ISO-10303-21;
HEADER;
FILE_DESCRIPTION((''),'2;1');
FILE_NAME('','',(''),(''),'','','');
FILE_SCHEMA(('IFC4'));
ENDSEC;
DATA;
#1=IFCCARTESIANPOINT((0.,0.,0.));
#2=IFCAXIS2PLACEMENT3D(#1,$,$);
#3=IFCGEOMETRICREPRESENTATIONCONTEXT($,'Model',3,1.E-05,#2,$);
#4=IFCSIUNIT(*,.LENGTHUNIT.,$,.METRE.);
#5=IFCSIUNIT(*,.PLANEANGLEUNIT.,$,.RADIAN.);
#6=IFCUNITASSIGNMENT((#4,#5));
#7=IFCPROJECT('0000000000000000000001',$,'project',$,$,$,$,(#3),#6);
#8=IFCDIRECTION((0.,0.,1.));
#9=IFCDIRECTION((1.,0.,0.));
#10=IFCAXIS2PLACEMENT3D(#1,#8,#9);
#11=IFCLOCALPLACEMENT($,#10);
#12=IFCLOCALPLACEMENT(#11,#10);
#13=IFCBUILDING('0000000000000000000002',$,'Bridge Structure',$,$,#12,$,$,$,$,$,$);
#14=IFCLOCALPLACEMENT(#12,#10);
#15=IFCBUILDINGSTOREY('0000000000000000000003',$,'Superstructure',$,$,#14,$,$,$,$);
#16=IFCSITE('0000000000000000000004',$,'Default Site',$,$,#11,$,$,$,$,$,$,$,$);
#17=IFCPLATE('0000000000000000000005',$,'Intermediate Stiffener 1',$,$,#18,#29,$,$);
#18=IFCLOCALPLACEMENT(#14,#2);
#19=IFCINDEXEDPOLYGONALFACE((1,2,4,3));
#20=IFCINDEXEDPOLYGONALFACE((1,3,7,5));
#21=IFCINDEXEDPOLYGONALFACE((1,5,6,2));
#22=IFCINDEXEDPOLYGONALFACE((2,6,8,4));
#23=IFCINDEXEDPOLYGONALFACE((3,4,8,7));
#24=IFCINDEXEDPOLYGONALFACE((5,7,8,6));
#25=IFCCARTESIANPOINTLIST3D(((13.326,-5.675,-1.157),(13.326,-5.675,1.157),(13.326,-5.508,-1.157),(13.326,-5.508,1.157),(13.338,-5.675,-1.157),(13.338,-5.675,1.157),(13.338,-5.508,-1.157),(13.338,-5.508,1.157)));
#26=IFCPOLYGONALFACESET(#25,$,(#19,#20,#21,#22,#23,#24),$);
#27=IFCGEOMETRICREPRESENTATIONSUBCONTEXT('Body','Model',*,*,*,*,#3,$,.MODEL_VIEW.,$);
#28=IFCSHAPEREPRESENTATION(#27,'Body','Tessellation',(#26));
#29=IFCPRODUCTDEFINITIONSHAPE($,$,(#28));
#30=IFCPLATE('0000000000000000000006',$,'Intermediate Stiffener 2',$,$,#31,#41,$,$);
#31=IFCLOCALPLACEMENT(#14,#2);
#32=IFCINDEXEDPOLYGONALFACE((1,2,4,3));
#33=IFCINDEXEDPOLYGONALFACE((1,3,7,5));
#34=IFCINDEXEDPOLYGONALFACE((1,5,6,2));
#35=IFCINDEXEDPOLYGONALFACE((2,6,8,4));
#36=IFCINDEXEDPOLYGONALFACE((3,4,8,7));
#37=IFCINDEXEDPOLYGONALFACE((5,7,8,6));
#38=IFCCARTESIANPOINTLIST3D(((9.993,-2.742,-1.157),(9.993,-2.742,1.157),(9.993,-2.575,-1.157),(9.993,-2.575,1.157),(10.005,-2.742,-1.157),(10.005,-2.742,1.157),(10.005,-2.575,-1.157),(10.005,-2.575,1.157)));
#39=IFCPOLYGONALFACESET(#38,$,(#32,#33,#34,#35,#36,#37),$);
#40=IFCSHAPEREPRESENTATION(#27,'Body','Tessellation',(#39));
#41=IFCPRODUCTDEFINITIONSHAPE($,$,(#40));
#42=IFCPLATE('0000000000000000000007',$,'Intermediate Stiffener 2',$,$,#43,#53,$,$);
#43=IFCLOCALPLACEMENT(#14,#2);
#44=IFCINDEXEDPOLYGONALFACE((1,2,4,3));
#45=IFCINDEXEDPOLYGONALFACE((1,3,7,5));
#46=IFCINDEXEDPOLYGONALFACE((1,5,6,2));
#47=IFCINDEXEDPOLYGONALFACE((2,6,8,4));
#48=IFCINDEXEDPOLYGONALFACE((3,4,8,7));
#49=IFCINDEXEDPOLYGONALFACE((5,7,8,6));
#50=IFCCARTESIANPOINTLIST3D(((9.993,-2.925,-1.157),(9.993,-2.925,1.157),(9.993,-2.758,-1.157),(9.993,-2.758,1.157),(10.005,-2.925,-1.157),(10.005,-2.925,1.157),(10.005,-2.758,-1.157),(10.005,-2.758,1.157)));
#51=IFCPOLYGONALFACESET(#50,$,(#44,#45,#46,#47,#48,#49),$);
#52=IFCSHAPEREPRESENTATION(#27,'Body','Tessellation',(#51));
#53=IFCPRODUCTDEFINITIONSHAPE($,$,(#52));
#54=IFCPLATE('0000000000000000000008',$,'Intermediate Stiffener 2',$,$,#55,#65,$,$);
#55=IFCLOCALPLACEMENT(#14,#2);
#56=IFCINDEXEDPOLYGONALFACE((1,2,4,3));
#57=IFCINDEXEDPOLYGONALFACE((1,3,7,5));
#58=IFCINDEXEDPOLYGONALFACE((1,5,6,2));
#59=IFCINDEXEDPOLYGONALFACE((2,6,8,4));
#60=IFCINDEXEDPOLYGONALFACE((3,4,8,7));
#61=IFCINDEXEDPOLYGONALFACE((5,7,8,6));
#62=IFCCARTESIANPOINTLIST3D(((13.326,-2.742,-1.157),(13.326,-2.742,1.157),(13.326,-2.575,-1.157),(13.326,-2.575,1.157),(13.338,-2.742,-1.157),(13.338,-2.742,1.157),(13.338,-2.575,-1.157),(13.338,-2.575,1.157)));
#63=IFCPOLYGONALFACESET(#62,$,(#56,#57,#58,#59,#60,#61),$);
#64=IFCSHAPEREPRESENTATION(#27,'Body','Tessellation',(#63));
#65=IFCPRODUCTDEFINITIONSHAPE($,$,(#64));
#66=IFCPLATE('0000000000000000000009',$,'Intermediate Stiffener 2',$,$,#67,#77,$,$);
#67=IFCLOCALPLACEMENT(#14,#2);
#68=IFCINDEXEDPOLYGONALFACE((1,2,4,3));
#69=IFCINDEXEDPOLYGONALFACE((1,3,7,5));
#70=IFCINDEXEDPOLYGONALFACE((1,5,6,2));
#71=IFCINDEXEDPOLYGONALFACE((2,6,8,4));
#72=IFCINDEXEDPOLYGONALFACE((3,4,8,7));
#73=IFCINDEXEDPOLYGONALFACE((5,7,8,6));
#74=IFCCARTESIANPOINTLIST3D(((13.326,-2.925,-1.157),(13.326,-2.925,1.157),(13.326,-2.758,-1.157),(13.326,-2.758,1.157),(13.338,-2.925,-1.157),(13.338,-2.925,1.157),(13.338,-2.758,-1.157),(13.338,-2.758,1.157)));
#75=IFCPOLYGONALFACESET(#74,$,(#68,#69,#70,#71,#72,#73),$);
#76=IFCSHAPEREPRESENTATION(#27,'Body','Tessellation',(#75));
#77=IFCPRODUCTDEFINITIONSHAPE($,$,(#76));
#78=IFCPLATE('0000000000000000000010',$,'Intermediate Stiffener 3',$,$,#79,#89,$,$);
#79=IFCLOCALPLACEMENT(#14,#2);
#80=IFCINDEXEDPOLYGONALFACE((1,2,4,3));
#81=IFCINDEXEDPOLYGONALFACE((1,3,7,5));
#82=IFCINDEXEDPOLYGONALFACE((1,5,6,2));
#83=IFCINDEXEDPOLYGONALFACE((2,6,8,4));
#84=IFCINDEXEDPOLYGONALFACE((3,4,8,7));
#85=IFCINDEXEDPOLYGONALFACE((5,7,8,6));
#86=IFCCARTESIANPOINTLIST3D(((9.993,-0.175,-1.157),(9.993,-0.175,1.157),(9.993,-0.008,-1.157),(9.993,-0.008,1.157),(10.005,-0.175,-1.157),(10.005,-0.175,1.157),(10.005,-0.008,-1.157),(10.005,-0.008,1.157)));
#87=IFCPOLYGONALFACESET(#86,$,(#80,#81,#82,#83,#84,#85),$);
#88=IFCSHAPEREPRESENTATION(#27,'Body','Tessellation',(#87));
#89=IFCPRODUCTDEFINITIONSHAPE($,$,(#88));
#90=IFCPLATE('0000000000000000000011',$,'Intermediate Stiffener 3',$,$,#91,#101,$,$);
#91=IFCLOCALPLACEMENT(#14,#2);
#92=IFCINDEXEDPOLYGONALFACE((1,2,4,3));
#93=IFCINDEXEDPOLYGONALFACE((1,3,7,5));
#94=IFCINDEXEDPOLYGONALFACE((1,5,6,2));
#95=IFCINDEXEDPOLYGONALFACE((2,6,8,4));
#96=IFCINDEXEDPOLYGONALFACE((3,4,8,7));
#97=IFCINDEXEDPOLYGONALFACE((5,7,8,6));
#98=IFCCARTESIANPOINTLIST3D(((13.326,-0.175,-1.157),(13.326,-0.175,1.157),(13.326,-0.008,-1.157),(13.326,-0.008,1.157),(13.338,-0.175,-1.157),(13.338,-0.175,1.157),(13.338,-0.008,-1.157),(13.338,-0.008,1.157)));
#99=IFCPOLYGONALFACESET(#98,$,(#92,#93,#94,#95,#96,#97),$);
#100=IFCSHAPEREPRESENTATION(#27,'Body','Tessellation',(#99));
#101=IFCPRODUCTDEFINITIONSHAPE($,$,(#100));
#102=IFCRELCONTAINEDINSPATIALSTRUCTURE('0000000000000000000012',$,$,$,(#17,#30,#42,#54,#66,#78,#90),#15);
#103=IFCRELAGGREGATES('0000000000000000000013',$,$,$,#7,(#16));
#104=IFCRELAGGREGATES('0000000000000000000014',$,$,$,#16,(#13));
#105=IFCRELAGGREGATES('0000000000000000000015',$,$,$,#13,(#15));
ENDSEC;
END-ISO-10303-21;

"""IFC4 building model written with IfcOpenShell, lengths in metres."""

from ifc_helpers import new_model, si_unit, frame, origin, origin_with_axes, origin_2d_with_axis, place, context, subcontext, project, spatial, rectangle, extrude, element, save


model = new_model("IFC4")

# Units and contexts
model_context = context("Model", 3, precision=1e-05, world=origin())
body_context = subcontext(model_context, "Body", "Model", "MODEL_VIEW")
ifc_project = project(units=[si_unit("LENGTHUNIT", "METRE"), si_unit("PLANEANGLEUNIT", "RADIAN")], contexts=[model_context])

# Site, building, storey
site_placement = place(None, origin_with_axes())
site = spatial("IfcSite", under=ifc_project, at=site_placement, Name="Default Site")
building_placement = place(site_placement, origin_with_axes())
building = spatial("IfcBuilding", under=site, at=building_placement, Name="Bridge Structure")
storey_placement = place(building_placement, origin_with_axes())
storey = spatial("IfcBuildingStorey", under=building, at=storey_placement, Name="Superstructure")

# Plates
for number, where, z_axis, x_axis, name in (
    (1, (13.332, -5.5915, -1.157), (0.0, 0.0, 1.0), (1.0, 0.0, 0.0), "Intermediate Stiffener 1"),
    (2, (9.999, -2.6585, -1.157), (0.0, 0.0, 1.0), (1.0, 0.0, 0.0), "Intermediate Stiffener 2"),
    (3, (9.999, -2.8415, -1.157), (0.0, 0.0, 1.0), (1.0, 0.0, 0.0), "Intermediate Stiffener 2"),
    (4, (13.332, -2.6585, -1.157), (0.0, 0.0, 1.0), (1.0, 0.0, 0.0), "Intermediate Stiffener 2"),
    (5, (13.332, -2.8415, -1.157), (0.0, 0.0, 1.0), (1.0, 0.0, 0.0), "Intermediate Stiffener 2"),
    (6, (9.999, -0.0915, -1.157), (0.0, 0.0, 1.0), (1.0, 0.0, 0.0), "Intermediate Stiffener 3"),
    (7, (13.332, -0.0915, -1.157), (0.0, 0.0, 1.0), (1.0, 0.0, 0.0), "Intermediate Stiffener 3"),
):
    element("IfcPlate", number, at=place(storey_placement, frame(where, z_axis=z_axis, x_axis=x_axis)), inside=storey, Name=name, context=body_context, shape_type="SweptSolid", body=[
        extrude(rectangle(XDim=0.012, YDim=0.167, at=origin_2d_with_axis()), origin_with_axes(), (0.0, 0.0, 1.0), 2.314),
    ])

save(model, "model.ifc")
